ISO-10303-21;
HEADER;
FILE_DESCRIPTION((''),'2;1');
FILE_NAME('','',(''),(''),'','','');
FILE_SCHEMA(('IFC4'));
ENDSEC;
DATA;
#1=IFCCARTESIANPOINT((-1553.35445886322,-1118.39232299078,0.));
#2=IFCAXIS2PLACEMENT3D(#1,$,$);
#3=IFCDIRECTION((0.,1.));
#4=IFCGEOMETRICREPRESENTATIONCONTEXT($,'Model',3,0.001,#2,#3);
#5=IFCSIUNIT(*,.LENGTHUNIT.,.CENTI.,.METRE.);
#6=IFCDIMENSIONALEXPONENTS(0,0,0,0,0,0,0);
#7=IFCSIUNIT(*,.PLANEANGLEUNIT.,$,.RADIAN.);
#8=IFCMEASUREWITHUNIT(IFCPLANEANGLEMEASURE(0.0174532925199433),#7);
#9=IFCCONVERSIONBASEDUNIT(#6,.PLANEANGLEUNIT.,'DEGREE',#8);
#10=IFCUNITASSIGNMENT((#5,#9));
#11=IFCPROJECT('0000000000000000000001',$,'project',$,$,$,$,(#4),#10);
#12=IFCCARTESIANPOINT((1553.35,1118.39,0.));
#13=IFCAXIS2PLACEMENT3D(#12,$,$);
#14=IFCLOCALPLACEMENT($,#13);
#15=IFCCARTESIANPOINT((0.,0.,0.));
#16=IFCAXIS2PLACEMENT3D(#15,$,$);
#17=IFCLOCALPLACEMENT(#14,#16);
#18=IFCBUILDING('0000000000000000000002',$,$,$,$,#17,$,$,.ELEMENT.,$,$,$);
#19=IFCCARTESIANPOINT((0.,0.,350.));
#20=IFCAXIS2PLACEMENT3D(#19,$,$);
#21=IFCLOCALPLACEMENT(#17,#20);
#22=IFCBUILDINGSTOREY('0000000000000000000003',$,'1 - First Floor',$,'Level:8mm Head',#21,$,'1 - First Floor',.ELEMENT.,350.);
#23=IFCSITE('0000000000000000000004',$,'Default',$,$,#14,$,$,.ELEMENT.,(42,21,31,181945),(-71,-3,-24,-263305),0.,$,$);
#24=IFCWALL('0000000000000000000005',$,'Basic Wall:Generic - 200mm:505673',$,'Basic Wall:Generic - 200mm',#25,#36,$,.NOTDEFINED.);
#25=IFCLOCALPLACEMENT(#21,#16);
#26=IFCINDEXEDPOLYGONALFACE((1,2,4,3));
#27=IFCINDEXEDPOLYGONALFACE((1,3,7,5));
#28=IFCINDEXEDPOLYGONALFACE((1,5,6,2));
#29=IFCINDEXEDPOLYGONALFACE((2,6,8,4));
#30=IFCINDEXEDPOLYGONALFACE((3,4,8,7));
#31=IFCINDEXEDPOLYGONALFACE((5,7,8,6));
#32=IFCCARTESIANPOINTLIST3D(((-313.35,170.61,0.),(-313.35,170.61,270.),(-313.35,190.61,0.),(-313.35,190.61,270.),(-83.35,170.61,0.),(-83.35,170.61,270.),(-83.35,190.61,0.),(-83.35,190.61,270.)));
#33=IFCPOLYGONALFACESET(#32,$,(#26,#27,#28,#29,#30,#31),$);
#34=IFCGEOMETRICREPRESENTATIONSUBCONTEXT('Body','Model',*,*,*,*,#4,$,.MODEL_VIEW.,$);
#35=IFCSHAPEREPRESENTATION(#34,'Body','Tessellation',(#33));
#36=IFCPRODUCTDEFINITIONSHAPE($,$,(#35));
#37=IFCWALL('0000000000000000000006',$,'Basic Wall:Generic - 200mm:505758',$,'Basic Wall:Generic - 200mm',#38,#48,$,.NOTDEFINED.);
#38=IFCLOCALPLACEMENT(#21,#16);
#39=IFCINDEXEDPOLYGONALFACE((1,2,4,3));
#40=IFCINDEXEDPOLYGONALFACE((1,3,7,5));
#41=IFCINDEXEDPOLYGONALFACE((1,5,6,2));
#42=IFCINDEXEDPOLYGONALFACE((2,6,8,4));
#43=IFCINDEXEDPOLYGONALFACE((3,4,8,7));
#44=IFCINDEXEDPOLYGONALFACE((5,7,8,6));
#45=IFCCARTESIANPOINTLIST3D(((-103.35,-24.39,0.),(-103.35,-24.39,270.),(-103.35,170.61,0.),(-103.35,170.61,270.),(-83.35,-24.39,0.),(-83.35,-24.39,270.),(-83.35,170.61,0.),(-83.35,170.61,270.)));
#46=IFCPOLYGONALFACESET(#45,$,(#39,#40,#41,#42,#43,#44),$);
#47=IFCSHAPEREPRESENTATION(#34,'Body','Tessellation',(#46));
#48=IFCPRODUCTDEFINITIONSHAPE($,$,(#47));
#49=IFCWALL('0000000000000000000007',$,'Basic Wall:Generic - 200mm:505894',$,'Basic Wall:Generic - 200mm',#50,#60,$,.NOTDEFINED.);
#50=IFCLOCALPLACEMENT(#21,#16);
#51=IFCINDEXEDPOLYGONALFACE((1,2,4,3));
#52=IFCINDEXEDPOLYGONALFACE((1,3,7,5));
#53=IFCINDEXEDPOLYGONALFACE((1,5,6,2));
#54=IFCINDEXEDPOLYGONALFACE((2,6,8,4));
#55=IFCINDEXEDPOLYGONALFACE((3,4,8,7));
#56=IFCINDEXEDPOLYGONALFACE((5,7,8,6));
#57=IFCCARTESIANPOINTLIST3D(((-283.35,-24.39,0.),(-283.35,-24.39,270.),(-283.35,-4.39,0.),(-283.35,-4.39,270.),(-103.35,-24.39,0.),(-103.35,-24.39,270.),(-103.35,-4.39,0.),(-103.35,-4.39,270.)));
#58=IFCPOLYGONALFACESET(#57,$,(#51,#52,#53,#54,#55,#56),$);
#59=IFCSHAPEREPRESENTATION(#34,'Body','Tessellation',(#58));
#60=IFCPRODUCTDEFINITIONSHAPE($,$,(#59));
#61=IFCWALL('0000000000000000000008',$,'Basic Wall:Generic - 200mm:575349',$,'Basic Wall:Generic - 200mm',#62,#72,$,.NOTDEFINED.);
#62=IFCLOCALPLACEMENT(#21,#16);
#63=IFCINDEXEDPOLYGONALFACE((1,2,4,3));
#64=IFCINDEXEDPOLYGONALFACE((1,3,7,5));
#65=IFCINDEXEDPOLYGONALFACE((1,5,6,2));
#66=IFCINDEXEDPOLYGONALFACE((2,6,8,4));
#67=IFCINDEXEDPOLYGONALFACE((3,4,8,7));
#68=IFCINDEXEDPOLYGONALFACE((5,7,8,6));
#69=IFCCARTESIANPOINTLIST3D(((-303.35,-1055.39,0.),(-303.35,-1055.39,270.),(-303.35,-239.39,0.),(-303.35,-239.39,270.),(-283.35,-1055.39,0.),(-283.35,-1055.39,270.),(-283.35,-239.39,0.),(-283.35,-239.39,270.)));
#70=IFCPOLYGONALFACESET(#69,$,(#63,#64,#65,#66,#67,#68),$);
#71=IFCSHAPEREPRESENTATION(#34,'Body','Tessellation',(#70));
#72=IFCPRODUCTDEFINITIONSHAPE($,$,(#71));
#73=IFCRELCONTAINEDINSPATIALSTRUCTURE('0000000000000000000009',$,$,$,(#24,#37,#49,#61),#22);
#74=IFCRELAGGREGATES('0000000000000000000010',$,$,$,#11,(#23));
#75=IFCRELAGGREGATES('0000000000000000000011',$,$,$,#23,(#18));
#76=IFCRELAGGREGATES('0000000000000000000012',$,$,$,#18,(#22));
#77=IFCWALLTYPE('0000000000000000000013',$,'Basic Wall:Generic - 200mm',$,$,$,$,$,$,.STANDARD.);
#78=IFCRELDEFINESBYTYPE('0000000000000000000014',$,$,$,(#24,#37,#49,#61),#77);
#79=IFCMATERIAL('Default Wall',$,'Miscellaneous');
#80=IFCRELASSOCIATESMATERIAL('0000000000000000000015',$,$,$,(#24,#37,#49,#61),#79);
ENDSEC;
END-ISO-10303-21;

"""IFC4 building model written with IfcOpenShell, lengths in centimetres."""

from ifc_helpers import new_model, entity, si_unit, converted_unit, direction, frame, origin, place, context, subcontext, project, spatial, indexed_curve, outline, extrude, material, type_object, element, save


model = new_model("IFC4")

# Units and contexts
model_context = context("Model", 3, precision=0.001, world=frame((-1553.35445886322, -1118.39232299078, 0.0)), true_north=direction((0.0, 1.0)))
body_context = subcontext(model_context, "Body", "Model", "MODEL_VIEW")
ifc_project = project(units=[si_unit("LENGTHUNIT", "METRE", prefix="CENTI"), converted_unit("PLANEANGLEUNIT", "DEGREE", entity("IfcPlaneAngleMeasure", 0.0174532925199433), si_unit("PLANEANGLEUNIT", "RADIAN"), dimensions=[0, 0, 0, 0, 0, 0, 0])], contexts=[model_context])

# Site, building, storey
site_placement = place(None, frame((1553.35, 1118.39, 0.0)))
site = spatial("IfcSite", under=ifc_project, at=site_placement, Name="Default", CompositionType="ELEMENT", RefLatitude=(42, 21, 31, 181945), RefLongitude=(-71, -3, -24, -263305), RefElevation=0.0)
building_placement = place(site_placement, origin())
building = spatial("IfcBuilding", under=site, at=building_placement, CompositionType="ELEMENT")
storey_placement = place(building_placement, frame((0.0, 0.0, 350.0)))
storey = spatial("IfcBuildingStorey", under=building, at=storey_placement, Name="1 - First Floor", ObjectType="Level:8mm Head", LongName="1 - First Floor", CompositionType="ELEMENT", Elevation=350.0)

# Walls
ifc_material_1 = material(Name="Default Wall", Category="Miscellaneous")
wall_type_1 = type_object("IfcWallType", Name="Basic Wall:Generic - 200mm", PredefinedType="STANDARD")
wall_1_placement = place(storey_placement, frame((-313.35, 180.61, 0.0)))
element("IfcWall", 1, at=wall_1_placement, inside=storey, type_object=wall_type_1, material=ifc_material_1, Name="Basic Wall:Generic - 200mm:505673", ObjectType="Basic Wall:Generic - 200mm", PredefinedType="NOTDEFINED", context=body_context, shape_type="SweptSolid", body=[
    extrude(outline(indexed_curve([(230.0, 10.0), (0.0, 10.0), (0.0, -10.0), (230.0, -10.0), (230.0, 10.0)], self_intersect=False)), origin(), (0.0, 0.0, 1.0), 270.0),
])
wall_2_placement = place(storey_placement, frame((-93.35, 170.61, 0.0), z_axis=(0.0, 0.0, 1.0), x_axis=(0.0, -1.0, 0.0)))
element("IfcWall", 2, at=wall_2_placement, inside=storey, type_object=wall_type_1, material=ifc_material_1, Name="Basic Wall:Generic - 200mm:505758", ObjectType="Basic Wall:Generic - 200mm", PredefinedType="NOTDEFINED", context=body_context, shape_type="SweptSolid", body=[
    extrude(outline(indexed_curve([(195.0, 10.0), (0.0, 10.0), (0.0, -10.0), (195.0, -10.0), (195.0, 10.0)], self_intersect=False)), origin(), (0.0, 0.0, 1.0), 270.0),
])
wall_3_placement = place(storey_placement, frame((-283.35, -14.39, 0.0)))
element("IfcWall", 3, at=wall_3_placement, inside=storey, type_object=wall_type_1, material=ifc_material_1, Name="Basic Wall:Generic - 200mm:505894", ObjectType="Basic Wall:Generic - 200mm", PredefinedType="NOTDEFINED", context=body_context, shape_type="SweptSolid", body=[
    extrude(outline(indexed_curve([(180.0, 10.0), (0.0, 10.0), (0.0, -10.0), (180.0, -10.0), (180.0, 10.0)], self_intersect=False)), origin(), (0.0, 0.0, 1.0), 270.0),
])
wall_4_placement = place(storey_placement, frame((-293.35, -239.39, 0.0), z_axis=(0.0, 0.0, 1.0), x_axis=(0.0, -1.0, 0.0)))
element("IfcWall", 4, at=wall_4_placement, inside=storey, type_object=wall_type_1, material=ifc_material_1, Name="Basic Wall:Generic - 200mm:575349", ObjectType="Basic Wall:Generic - 200mm", PredefinedType="NOTDEFINED", context=body_context, shape_type="SweptSolid", body=[
    extrude(outline(indexed_curve([(816.0, 10.0), (0.0, 10.0), (0.0, -10.0), (816.0, -10.0), (816.0, 10.0)], self_intersect=False)), origin(), (0.0, 0.0, 1.0), 270.0),
])

save(model, "model.ifc")
